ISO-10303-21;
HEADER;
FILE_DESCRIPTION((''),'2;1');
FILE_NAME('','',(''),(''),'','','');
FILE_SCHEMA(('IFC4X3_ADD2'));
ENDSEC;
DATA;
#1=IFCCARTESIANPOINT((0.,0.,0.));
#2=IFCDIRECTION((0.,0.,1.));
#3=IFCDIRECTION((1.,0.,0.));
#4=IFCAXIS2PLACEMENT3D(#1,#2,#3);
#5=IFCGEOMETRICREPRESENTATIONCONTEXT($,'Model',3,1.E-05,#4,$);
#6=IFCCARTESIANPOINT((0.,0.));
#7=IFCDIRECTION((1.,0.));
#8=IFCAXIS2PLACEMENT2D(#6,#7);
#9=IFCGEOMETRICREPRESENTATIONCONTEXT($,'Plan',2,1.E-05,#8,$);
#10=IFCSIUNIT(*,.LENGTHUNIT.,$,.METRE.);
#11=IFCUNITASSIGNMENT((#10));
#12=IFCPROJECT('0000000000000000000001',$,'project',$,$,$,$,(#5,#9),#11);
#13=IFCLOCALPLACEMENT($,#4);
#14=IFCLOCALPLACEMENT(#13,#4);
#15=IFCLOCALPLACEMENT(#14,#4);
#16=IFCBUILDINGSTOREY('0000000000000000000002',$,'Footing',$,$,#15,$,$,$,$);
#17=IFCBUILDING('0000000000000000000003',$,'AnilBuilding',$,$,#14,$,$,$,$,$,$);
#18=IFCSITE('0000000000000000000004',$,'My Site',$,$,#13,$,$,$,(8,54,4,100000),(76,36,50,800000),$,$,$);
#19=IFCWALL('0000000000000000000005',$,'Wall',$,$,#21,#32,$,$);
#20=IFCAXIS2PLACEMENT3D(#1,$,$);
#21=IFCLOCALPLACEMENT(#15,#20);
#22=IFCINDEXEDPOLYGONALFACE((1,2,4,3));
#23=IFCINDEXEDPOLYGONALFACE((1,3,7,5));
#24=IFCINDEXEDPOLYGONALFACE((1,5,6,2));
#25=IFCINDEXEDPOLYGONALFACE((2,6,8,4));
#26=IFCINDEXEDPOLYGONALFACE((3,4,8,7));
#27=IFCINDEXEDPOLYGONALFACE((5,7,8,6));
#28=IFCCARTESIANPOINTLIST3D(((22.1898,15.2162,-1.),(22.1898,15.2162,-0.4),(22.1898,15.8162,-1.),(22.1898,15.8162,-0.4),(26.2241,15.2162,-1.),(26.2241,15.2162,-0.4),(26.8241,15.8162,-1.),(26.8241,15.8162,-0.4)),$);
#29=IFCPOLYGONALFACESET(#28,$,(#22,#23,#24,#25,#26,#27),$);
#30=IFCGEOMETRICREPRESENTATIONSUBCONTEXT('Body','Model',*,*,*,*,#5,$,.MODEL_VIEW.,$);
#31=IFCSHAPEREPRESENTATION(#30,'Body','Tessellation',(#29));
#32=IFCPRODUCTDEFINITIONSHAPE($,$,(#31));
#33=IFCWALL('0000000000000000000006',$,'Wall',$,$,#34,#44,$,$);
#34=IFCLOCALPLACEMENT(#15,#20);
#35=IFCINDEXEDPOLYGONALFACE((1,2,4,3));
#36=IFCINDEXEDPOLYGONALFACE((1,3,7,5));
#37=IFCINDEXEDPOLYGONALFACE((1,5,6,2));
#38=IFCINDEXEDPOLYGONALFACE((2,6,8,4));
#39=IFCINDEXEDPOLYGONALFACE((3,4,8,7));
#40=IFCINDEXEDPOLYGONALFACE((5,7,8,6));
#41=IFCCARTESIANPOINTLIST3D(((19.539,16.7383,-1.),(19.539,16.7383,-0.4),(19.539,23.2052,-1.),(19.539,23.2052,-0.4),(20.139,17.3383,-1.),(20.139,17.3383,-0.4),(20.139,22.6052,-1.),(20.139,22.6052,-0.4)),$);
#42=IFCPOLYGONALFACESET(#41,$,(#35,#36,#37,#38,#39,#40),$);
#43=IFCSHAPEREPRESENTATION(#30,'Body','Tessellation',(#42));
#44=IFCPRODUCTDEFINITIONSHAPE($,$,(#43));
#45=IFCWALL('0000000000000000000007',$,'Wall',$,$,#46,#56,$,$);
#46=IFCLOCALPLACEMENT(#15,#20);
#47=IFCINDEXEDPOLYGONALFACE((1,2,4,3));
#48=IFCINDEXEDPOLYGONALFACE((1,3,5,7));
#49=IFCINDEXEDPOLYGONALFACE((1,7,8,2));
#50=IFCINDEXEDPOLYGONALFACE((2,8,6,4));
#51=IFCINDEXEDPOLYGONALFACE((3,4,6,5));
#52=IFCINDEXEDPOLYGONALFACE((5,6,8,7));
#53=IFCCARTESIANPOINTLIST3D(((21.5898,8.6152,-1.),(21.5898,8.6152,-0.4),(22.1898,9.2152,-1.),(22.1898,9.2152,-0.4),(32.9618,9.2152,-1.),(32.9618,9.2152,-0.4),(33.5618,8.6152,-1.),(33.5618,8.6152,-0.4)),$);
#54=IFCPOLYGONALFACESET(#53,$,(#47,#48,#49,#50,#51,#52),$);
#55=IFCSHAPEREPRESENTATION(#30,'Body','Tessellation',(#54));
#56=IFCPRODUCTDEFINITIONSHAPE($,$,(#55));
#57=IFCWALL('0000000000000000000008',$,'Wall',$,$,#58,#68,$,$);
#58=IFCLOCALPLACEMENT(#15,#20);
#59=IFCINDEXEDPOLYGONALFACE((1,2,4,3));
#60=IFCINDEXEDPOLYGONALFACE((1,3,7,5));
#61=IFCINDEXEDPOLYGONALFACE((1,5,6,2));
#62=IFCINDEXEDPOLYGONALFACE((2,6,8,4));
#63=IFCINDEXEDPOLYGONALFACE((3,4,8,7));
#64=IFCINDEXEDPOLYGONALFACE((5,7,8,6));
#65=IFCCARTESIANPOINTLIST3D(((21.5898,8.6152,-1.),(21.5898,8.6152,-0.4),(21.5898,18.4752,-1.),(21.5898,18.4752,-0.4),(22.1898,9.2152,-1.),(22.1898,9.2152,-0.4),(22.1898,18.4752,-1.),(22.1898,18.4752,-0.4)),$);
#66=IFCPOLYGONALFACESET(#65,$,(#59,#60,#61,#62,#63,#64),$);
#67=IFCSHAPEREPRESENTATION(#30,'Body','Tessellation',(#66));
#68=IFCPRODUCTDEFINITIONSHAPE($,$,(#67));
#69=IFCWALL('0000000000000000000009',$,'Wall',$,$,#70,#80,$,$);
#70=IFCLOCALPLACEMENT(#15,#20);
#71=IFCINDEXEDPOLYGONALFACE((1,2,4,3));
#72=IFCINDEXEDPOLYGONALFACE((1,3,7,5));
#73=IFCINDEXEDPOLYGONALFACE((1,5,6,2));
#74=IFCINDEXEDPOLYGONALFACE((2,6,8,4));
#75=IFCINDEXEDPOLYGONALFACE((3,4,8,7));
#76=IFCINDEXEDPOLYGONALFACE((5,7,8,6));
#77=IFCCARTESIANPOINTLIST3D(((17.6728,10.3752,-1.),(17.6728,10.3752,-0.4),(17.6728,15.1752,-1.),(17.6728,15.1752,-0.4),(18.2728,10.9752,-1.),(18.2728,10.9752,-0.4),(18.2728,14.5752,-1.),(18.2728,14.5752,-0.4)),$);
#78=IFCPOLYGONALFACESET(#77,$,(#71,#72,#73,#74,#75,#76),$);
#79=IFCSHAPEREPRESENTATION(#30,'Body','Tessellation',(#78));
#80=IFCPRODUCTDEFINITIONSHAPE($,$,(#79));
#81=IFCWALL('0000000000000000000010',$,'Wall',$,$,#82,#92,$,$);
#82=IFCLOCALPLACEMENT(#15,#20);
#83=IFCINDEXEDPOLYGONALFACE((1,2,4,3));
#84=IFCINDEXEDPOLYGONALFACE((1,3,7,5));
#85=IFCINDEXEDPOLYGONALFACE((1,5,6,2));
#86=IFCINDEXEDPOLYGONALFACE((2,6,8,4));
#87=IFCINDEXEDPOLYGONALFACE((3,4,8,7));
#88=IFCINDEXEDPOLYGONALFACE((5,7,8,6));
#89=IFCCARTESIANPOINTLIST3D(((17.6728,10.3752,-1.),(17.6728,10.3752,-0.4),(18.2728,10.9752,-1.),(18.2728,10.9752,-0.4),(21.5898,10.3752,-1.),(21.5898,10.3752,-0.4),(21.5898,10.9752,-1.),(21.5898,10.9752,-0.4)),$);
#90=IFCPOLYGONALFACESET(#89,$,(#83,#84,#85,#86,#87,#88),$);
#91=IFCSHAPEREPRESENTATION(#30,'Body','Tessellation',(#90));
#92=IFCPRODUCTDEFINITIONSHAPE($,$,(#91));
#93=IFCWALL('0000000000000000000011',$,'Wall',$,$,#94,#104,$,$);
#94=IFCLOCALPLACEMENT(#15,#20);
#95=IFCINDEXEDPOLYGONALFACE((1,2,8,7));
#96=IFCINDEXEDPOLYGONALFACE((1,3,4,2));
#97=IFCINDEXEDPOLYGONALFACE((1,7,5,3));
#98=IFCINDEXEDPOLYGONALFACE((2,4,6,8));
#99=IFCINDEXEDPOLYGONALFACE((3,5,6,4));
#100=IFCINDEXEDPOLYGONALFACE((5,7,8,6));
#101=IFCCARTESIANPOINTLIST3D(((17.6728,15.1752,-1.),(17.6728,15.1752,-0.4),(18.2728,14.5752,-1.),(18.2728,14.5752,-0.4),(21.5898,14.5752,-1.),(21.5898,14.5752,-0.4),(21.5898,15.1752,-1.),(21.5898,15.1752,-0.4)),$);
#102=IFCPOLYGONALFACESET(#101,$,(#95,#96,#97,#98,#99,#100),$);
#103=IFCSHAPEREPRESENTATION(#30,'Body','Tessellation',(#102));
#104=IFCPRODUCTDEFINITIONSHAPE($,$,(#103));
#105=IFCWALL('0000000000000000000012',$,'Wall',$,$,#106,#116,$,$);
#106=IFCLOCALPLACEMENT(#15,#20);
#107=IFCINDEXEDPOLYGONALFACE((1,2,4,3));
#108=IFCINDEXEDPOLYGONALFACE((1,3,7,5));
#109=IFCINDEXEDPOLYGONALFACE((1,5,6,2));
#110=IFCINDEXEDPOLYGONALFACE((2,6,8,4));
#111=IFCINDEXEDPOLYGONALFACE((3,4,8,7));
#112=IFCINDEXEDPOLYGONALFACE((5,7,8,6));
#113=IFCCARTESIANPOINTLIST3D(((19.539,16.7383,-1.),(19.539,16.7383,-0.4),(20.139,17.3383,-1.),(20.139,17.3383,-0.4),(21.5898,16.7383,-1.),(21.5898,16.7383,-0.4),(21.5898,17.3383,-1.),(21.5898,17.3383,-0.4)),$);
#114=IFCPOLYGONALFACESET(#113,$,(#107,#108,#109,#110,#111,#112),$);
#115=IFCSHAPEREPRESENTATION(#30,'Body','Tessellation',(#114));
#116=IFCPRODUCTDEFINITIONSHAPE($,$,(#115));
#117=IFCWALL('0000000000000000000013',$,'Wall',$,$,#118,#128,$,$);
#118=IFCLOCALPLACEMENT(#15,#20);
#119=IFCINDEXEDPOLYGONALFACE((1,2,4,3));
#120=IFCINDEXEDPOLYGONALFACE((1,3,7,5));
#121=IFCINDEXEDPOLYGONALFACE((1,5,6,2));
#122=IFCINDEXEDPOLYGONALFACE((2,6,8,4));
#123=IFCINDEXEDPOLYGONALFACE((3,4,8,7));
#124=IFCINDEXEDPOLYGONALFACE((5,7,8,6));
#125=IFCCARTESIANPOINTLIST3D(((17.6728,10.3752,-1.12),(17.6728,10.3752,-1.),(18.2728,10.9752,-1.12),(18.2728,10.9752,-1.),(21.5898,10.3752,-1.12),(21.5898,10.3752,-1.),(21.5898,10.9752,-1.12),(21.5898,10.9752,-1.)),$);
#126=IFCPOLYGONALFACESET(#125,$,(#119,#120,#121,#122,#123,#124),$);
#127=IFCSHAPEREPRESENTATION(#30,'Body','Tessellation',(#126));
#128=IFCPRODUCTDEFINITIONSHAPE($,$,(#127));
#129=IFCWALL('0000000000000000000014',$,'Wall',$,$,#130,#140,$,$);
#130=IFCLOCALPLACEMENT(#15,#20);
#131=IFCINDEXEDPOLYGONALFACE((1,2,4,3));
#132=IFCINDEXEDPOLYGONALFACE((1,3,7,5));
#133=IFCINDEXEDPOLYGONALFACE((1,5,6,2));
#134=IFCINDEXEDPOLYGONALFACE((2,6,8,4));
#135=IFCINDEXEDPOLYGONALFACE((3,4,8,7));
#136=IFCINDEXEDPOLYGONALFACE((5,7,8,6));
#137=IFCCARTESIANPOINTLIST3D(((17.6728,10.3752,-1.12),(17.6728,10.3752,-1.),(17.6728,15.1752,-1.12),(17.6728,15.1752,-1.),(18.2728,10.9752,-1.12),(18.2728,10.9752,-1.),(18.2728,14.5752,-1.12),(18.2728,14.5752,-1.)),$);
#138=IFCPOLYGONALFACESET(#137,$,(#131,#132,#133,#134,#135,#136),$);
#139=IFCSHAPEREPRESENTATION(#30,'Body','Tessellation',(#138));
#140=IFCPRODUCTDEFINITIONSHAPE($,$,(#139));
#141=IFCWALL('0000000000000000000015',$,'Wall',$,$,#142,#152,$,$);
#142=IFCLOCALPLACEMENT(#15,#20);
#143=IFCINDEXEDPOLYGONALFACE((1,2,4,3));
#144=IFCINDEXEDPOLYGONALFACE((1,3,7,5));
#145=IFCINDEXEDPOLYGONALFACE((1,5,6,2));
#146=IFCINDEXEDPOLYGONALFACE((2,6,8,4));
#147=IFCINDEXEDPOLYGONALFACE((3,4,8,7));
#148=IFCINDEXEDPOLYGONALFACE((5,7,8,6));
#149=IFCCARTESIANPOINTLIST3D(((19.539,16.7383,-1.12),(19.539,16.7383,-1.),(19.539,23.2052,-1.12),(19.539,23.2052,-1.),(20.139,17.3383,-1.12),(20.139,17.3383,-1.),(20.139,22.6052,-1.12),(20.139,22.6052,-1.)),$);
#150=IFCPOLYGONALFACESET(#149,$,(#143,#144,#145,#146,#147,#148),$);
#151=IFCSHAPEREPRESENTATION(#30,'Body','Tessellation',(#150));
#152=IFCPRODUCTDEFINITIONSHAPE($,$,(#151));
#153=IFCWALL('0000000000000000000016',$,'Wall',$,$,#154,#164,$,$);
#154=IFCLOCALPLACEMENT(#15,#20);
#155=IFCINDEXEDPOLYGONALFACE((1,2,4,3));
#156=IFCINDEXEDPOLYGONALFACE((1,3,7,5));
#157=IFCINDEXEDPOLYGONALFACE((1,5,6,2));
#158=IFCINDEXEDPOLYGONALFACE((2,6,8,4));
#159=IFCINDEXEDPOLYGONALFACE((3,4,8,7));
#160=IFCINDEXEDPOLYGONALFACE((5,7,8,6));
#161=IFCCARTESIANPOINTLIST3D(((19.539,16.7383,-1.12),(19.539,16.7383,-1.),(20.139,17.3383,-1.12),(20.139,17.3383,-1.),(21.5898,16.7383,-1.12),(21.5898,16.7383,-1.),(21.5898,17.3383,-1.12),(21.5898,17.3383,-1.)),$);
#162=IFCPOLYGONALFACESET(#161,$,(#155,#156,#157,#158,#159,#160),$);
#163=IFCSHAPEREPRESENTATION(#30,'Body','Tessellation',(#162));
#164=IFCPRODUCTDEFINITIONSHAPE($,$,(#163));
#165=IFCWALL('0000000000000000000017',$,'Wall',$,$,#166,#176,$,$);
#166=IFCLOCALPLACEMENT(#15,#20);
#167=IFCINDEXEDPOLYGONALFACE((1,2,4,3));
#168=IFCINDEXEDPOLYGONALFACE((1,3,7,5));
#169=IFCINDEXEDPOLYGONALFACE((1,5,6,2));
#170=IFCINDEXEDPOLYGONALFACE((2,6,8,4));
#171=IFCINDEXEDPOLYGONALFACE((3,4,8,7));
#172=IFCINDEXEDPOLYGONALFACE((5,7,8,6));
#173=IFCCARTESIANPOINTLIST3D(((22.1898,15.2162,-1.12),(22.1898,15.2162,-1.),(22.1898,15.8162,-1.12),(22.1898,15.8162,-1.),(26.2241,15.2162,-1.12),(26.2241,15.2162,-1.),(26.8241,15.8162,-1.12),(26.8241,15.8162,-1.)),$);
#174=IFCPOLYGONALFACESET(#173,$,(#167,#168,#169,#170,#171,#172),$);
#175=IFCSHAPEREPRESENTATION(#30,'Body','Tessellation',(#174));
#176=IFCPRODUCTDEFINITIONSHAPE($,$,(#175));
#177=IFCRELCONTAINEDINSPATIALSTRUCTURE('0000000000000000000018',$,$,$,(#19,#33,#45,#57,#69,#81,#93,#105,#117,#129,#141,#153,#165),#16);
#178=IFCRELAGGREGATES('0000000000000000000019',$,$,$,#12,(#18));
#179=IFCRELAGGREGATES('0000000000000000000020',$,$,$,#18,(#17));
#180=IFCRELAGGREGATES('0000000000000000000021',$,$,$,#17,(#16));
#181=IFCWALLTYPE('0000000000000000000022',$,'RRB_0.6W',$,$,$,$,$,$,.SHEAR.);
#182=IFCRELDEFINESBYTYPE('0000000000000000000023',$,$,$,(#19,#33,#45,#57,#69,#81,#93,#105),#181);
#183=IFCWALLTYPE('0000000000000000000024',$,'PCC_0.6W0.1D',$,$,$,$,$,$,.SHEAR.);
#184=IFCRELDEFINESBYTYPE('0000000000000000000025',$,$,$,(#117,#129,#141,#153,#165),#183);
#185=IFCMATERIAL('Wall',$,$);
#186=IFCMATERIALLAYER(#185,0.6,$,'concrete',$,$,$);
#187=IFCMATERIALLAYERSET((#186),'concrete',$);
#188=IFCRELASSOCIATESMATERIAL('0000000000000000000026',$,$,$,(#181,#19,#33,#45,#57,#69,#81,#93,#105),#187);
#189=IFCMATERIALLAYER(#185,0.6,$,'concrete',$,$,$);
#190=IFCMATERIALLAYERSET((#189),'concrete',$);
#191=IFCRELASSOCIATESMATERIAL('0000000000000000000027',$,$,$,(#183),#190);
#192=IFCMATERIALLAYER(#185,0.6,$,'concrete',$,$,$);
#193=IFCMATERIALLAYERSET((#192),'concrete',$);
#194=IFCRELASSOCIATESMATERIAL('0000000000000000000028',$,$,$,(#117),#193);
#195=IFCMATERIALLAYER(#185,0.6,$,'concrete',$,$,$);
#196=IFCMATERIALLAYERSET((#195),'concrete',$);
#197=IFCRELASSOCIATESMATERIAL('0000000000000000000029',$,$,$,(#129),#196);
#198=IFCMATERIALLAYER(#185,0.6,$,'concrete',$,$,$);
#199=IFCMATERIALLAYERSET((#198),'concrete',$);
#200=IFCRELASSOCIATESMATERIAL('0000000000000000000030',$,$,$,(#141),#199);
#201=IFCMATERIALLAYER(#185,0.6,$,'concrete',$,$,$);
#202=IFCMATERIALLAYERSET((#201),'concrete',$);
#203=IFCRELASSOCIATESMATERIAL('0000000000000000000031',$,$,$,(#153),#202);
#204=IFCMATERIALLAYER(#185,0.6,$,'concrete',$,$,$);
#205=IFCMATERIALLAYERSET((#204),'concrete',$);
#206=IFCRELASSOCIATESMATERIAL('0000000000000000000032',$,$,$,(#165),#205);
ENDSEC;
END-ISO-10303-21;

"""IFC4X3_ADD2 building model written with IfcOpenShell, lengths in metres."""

from ifc_helpers import new_model, si_unit, frame, origin_with_axes, origin_2d_with_axis, place, context, subcontext, project, spatial, line, indexed_curve, outline, extrude, material, layer, layer_set, layer_usage, type_object, element, save


model = new_model("IFC4X3_ADD2")

# Units and contexts
model_context = context("Model", 3, precision=1e-05, world=origin_with_axes())
plan_context = context("Plan", 2, precision=1e-05, world=origin_2d_with_axis())
body_context = subcontext(model_context, "Body", "Model", "MODEL_VIEW")
ifc_project = project(units=[si_unit("LENGTHUNIT", "METRE")], contexts=[model_context, plan_context])

# Site, building, storey
site_placement = place(None, origin_with_axes())
site = spatial("IfcSite", under=ifc_project, at=site_placement, Name="My Site", RefLatitude=(8, 54, 4, 100000), RefLongitude=(76, 36, 50, 800000))
building_placement = place(site_placement, origin_with_axes())
building = spatial("IfcBuilding", under=site, at=building_placement, Name="AnilBuilding")
storey_placement = place(building_placement, origin_with_axes())
storey = spatial("IfcBuildingStorey", under=building, at=storey_placement, Name="Footing")

# Walls
ifc_material_1 = material(Name="Wall")
ifc_layer_1 = layer(ifc_material_1, 0.6, Name="concrete")
ifc_layer_set_1 = layer_set([ifc_layer_1], Name="concrete")
ifc_layer_usage_1 = layer_usage(ifc_layer_set_1, "AXIS2", "POSITIVE", 0.0)
wall_type_1 = type_object("IfcWallType", Name="RRB_0.6W", PredefinedType="SHEAR", material=ifc_layer_set_1)
wall_1_placement = place(storey_placement, frame((22.1898, 15.2162, -1.0), z_axis=(0.0, 0.0, 1.0), x_axis=(1.0, 0.0, 0.0)))
element("IfcWall", 1, at=wall_1_placement, inside=storey, type_object=wall_type_1, material=ifc_layer_usage_1, Name="Wall", context=body_context, shape_type="SweptSolid", body=[
    extrude(outline(indexed_curve([(0.0, 0.0), (0.0, 0.6), (4.6343, 0.6), (4.0343, 0.0)], segments=[line(1, 2, 3, 4, 1)])), origin_with_axes(), (0.0, 0.0, 1.0), 0.6),
])
ifc_layer_usage_2 = layer_usage(ifc_layer_set_1, "AXIS2", "POSITIVE", 0.0)
wall_2_placement = place(storey_placement, frame((20.139, 16.7383, -1.0), z_axis=(0.0, 0.0, 1.0), x_axis=(0.000001, 1.0, 0.0)))
element("IfcWall", 2, at=wall_2_placement, inside=storey, type_object=wall_type_1, material=ifc_layer_usage_2, Name="Wall", context=body_context, shape_type="SweptSolid", body=[
    extrude(outline(indexed_curve([(0.6, 0.0), (0.0, 0.6), (6.4669, 0.6), (5.8669, 0.0)], segments=[line(1, 2, 3, 4, 1)])), origin_with_axes(), (0.0, 0.0, 1.0), 0.6),
])
ifc_layer_usage_3 = layer_usage(ifc_layer_set_1, "AXIS2", "POSITIVE", 0.0)
wall_3_placement = place(storey_placement, frame((22.1898, 8.6152, -1.0), z_axis=(0.0, 0.0, 1.0), x_axis=(1.0, 0.0, 0.0)))
element("IfcWall", 3, at=wall_3_placement, inside=storey, type_object=wall_type_1, material=ifc_layer_usage_3, Name="Wall", context=body_context, shape_type="SweptSolid", body=[
    extrude(outline(indexed_curve([(-0.6, 0.0), (0.0, 0.6), (10.772, 0.6), (11.372, 0.0)], segments=[line(1, 2, 3, 4, 1)])), origin_with_axes(), (0.0, 0.0, 1.0), 0.6),
])
ifc_layer_usage_4 = layer_usage(ifc_layer_set_1, "AXIS2", "POSITIVE", 0.0)
wall_4_placement = place(storey_placement, frame((22.1898, 8.6152, -1.0), z_axis=(0.0, 0.0, 1.0), x_axis=(0.000001, 1.0, 0.0)))
element("IfcWall", 4, at=wall_4_placement, inside=storey, type_object=wall_type_1, material=ifc_layer_usage_4, Name="Wall", context=body_context, shape_type="SweptSolid", body=[
    extrude(outline(indexed_curve([(0.6, 0.0), (0.0, 0.6), (9.86, 0.6), (9.86, 0.0)], segments=[line(1, 2, 3, 4, 1)])), origin_with_axes(), (0.0, 0.0, 1.0), 0.6),
])
ifc_layer_usage_5 = layer_usage(ifc_layer_set_1, "AXIS2", "POSITIVE", 0.0)
wall_5_placement = place(storey_placement, frame((18.2728, 10.3752, -1.0), z_axis=(0.0, 0.0, 1.0), x_axis=(0.000001, 1.0, 0.0)))
element("IfcWall", 5, at=wall_5_placement, inside=storey, type_object=wall_type_1, material=ifc_layer_usage_5, Name="Wall", context=body_context, shape_type="SweptSolid", body=[
    extrude(outline(indexed_curve([(0.6, 0.0), (0.0, 0.6), (4.8, 0.6), (4.2, 0.0)], segments=[line(1, 2, 3, 4, 1)])), origin_with_axes(), (0.0, 0.0, 1.0), 0.6),
])
ifc_layer_usage_6 = layer_usage(ifc_layer_set_1, "AXIS2", "POSITIVE", 0.0)
wall_6_placement = place(storey_placement, frame((18.2728, 10.3752, -1.0), z_axis=(0.0, 0.0, 1.0), x_axis=(1.0, 0.0, 0.0)))
element("IfcWall", 6, at=wall_6_placement, inside=storey, type_object=wall_type_1, material=ifc_layer_usage_6, Name="Wall", context=body_context, shape_type="SweptSolid", body=[
    extrude(outline(indexed_curve([(-0.6, 0.0), (0.0, 0.6), (3.317, 0.6), (3.317, 0.0)], segments=[line(1, 2, 3, 4, 1)])), origin_with_axes(), (0.0, 0.0, 1.0), 0.6),
])
ifc_layer_usage_7 = layer_usage(ifc_layer_set_1, "AXIS2", "POSITIVE", 0.0)
wall_7_placement = place(storey_placement, frame((18.2728, 14.5752, -1.0), z_axis=(0.0, 0.0, 1.0), x_axis=(1.0, 0.0, 0.0)))
element("IfcWall", 7, at=wall_7_placement, inside=storey, type_object=wall_type_1, material=ifc_layer_usage_7, Name="Wall", context=body_context, shape_type="SweptSolid", body=[
    extrude(outline(indexed_curve([(0.0, 0.0), (-0.6, 0.6), (3.317, 0.6), (3.317, 0.0)], segments=[line(1, 2, 3, 4, 1)])), origin_with_axes(), (0.0, 0.0, 1.0), 0.6),
])
ifc_layer_usage_8 = layer_usage(ifc_layer_set_1, "AXIS2", "POSITIVE", 0.0)
wall_8_placement = place(storey_placement, frame((20.139, 16.7383, -1.0), z_axis=(0.0, 0.0, 1.0), x_axis=(1.0, 0.0, 0.0)))
element("IfcWall", 8, at=wall_8_placement, inside=storey, type_object=wall_type_1, material=ifc_layer_usage_8, Name="Wall", context=body_context, shape_type="SweptSolid", body=[
    extrude(outline(indexed_curve([(-0.6, 0.0), (0.0, 0.6), (1.4508, 0.6), (1.4508, 0.0)], segments=[line(1, 2, 3, 4, 1)])), origin_with_axes(), (0.0, 0.0, 1.0), 0.6),
])
ifc_layer_2 = layer(ifc_material_1, 0.6, Name="concrete")
ifc_layer_set_2 = layer_set([ifc_layer_2], Name="concrete")
ifc_layer_usage_9 = layer_usage(ifc_layer_set_2, "AXIS2", "POSITIVE", 0.0)
ifc_layer_3 = layer(ifc_material_1, 0.6, Name="concrete")
ifc_layer_set_3 = layer_set([ifc_layer_3], Name="concrete")
wall_type_2 = type_object("IfcWallType", Name="PCC_0.6W0.1D", PredefinedType="SHEAR", material=ifc_layer_set_3)
wall_9_placement = place(storey_placement, frame((18.2728, 10.3752, -1.12), z_axis=(0.0, 0.0, 1.0), x_axis=(1.0, 0.0, 0.0)))
element("IfcWall", 9, at=wall_9_placement, inside=storey, type_object=wall_type_2, material=ifc_layer_usage_9, Name="Wall", context=body_context, shape_type="SweptSolid", body=[
    extrude(outline(indexed_curve([(-0.6, 0.0), (0.0, 0.6), (3.317, 0.6), (3.317, 0.0)], segments=[line(1, 2, 3, 4, 1)])), origin_with_axes(), (0.0, 0.0, 1.0), 0.12),
])
ifc_layer_4 = layer(ifc_material_1, 0.6, Name="concrete")
ifc_layer_set_4 = layer_set([ifc_layer_4], Name="concrete")
ifc_layer_usage_10 = layer_usage(ifc_layer_set_4, "AXIS2", "POSITIVE", 0.0)
wall_10_placement = place(storey_placement, frame((18.2728, 10.3752, -1.12), z_axis=(0.0, 0.0, 1.0), x_axis=(0.000001, 1.0, 0.0)))
element("IfcWall", 10, at=wall_10_placement, inside=storey, type_object=wall_type_2, material=ifc_layer_usage_10, Name="Wall", context=body_context, shape_type="SweptSolid", body=[
    extrude(outline(indexed_curve([(0.6, 0.0), (0.0, 0.6), (4.8, 0.6), (4.2, 0.0)], segments=[line(1, 2, 3, 4, 1)])), origin_with_axes(), (0.0, 0.0, 1.0), 0.12),
])
ifc_layer_5 = layer(ifc_material_1, 0.6, Name="concrete")
ifc_layer_set_5 = layer_set([ifc_layer_5], Name="concrete")
ifc_layer_usage_11 = layer_usage(ifc_layer_set_5, "AXIS2", "POSITIVE", 0.0)
wall_11_placement = place(storey_placement, frame((20.139, 16.7383, -1.12), z_axis=(0.0, 0.0, 1.0), x_axis=(0.000001, 1.0, 0.0)))
element("IfcWall", 11, at=wall_11_placement, inside=storey, type_object=wall_type_2, material=ifc_layer_usage_11, Name="Wall", context=body_context, shape_type="SweptSolid", body=[
    extrude(outline(indexed_curve([(0.6, 0.0), (0.0, 0.6), (6.4669, 0.6), (5.8669, 0.0)], segments=[line(1, 2, 3, 4, 1)])), origin_with_axes(), (0.0, 0.0, 1.0), 0.12),
])
ifc_layer_6 = layer(ifc_material_1, 0.6, Name="concrete")
ifc_layer_set_6 = layer_set([ifc_layer_6], Name="concrete")
ifc_layer_usage_12 = layer_usage(ifc_layer_set_6, "AXIS2", "POSITIVE", 0.0)
wall_12_placement = place(storey_placement, frame((20.139, 16.7383, -1.12), z_axis=(0.0, 0.0, 1.0), x_axis=(1.0, 0.0, 0.0)))
element("IfcWall", 12, at=wall_12_placement, inside=storey, type_object=wall_type_2, material=ifc_layer_usage_12, Name="Wall", context=body_context, shape_type="SweptSolid", body=[
    extrude(outline(indexed_curve([(-0.6, 0.0), (0.0, 0.6), (1.4508, 0.6), (1.4508, 0.0)], segments=[line(1, 2, 3, 4, 1)])), origin_with_axes(), (0.0, 0.0, 1.0), 0.12),
])
ifc_layer_7 = layer(ifc_material_1, 0.6, Name="concrete")
ifc_layer_set_7 = layer_set([ifc_layer_7], Name="concrete")
ifc_layer_usage_13 = layer_usage(ifc_layer_set_7, "AXIS2", "POSITIVE", 0.0)
wall_13_placement = place(storey_placement, frame((22.1898, 15.2162, -1.12), z_axis=(0.0, 0.0, 1.0), x_axis=(1.0, 0.0, 0.0)))
element("IfcWall", 13, at=wall_13_placement, inside=storey, type_object=wall_type_2, material=ifc_layer_usage_13, Name="Wall", context=body_context, shape_type="SweptSolid", body=[
    extrude(outline(indexed_curve([(0.0, 0.0), (0.0, 0.6), (4.6343, 0.6), (4.0343, 0.0)], segments=[line(1, 2, 3, 4, 1)])), origin_with_axes(), (0.0, 0.0, 1.0), 0.12),
])

save(model, "model.ifc")
